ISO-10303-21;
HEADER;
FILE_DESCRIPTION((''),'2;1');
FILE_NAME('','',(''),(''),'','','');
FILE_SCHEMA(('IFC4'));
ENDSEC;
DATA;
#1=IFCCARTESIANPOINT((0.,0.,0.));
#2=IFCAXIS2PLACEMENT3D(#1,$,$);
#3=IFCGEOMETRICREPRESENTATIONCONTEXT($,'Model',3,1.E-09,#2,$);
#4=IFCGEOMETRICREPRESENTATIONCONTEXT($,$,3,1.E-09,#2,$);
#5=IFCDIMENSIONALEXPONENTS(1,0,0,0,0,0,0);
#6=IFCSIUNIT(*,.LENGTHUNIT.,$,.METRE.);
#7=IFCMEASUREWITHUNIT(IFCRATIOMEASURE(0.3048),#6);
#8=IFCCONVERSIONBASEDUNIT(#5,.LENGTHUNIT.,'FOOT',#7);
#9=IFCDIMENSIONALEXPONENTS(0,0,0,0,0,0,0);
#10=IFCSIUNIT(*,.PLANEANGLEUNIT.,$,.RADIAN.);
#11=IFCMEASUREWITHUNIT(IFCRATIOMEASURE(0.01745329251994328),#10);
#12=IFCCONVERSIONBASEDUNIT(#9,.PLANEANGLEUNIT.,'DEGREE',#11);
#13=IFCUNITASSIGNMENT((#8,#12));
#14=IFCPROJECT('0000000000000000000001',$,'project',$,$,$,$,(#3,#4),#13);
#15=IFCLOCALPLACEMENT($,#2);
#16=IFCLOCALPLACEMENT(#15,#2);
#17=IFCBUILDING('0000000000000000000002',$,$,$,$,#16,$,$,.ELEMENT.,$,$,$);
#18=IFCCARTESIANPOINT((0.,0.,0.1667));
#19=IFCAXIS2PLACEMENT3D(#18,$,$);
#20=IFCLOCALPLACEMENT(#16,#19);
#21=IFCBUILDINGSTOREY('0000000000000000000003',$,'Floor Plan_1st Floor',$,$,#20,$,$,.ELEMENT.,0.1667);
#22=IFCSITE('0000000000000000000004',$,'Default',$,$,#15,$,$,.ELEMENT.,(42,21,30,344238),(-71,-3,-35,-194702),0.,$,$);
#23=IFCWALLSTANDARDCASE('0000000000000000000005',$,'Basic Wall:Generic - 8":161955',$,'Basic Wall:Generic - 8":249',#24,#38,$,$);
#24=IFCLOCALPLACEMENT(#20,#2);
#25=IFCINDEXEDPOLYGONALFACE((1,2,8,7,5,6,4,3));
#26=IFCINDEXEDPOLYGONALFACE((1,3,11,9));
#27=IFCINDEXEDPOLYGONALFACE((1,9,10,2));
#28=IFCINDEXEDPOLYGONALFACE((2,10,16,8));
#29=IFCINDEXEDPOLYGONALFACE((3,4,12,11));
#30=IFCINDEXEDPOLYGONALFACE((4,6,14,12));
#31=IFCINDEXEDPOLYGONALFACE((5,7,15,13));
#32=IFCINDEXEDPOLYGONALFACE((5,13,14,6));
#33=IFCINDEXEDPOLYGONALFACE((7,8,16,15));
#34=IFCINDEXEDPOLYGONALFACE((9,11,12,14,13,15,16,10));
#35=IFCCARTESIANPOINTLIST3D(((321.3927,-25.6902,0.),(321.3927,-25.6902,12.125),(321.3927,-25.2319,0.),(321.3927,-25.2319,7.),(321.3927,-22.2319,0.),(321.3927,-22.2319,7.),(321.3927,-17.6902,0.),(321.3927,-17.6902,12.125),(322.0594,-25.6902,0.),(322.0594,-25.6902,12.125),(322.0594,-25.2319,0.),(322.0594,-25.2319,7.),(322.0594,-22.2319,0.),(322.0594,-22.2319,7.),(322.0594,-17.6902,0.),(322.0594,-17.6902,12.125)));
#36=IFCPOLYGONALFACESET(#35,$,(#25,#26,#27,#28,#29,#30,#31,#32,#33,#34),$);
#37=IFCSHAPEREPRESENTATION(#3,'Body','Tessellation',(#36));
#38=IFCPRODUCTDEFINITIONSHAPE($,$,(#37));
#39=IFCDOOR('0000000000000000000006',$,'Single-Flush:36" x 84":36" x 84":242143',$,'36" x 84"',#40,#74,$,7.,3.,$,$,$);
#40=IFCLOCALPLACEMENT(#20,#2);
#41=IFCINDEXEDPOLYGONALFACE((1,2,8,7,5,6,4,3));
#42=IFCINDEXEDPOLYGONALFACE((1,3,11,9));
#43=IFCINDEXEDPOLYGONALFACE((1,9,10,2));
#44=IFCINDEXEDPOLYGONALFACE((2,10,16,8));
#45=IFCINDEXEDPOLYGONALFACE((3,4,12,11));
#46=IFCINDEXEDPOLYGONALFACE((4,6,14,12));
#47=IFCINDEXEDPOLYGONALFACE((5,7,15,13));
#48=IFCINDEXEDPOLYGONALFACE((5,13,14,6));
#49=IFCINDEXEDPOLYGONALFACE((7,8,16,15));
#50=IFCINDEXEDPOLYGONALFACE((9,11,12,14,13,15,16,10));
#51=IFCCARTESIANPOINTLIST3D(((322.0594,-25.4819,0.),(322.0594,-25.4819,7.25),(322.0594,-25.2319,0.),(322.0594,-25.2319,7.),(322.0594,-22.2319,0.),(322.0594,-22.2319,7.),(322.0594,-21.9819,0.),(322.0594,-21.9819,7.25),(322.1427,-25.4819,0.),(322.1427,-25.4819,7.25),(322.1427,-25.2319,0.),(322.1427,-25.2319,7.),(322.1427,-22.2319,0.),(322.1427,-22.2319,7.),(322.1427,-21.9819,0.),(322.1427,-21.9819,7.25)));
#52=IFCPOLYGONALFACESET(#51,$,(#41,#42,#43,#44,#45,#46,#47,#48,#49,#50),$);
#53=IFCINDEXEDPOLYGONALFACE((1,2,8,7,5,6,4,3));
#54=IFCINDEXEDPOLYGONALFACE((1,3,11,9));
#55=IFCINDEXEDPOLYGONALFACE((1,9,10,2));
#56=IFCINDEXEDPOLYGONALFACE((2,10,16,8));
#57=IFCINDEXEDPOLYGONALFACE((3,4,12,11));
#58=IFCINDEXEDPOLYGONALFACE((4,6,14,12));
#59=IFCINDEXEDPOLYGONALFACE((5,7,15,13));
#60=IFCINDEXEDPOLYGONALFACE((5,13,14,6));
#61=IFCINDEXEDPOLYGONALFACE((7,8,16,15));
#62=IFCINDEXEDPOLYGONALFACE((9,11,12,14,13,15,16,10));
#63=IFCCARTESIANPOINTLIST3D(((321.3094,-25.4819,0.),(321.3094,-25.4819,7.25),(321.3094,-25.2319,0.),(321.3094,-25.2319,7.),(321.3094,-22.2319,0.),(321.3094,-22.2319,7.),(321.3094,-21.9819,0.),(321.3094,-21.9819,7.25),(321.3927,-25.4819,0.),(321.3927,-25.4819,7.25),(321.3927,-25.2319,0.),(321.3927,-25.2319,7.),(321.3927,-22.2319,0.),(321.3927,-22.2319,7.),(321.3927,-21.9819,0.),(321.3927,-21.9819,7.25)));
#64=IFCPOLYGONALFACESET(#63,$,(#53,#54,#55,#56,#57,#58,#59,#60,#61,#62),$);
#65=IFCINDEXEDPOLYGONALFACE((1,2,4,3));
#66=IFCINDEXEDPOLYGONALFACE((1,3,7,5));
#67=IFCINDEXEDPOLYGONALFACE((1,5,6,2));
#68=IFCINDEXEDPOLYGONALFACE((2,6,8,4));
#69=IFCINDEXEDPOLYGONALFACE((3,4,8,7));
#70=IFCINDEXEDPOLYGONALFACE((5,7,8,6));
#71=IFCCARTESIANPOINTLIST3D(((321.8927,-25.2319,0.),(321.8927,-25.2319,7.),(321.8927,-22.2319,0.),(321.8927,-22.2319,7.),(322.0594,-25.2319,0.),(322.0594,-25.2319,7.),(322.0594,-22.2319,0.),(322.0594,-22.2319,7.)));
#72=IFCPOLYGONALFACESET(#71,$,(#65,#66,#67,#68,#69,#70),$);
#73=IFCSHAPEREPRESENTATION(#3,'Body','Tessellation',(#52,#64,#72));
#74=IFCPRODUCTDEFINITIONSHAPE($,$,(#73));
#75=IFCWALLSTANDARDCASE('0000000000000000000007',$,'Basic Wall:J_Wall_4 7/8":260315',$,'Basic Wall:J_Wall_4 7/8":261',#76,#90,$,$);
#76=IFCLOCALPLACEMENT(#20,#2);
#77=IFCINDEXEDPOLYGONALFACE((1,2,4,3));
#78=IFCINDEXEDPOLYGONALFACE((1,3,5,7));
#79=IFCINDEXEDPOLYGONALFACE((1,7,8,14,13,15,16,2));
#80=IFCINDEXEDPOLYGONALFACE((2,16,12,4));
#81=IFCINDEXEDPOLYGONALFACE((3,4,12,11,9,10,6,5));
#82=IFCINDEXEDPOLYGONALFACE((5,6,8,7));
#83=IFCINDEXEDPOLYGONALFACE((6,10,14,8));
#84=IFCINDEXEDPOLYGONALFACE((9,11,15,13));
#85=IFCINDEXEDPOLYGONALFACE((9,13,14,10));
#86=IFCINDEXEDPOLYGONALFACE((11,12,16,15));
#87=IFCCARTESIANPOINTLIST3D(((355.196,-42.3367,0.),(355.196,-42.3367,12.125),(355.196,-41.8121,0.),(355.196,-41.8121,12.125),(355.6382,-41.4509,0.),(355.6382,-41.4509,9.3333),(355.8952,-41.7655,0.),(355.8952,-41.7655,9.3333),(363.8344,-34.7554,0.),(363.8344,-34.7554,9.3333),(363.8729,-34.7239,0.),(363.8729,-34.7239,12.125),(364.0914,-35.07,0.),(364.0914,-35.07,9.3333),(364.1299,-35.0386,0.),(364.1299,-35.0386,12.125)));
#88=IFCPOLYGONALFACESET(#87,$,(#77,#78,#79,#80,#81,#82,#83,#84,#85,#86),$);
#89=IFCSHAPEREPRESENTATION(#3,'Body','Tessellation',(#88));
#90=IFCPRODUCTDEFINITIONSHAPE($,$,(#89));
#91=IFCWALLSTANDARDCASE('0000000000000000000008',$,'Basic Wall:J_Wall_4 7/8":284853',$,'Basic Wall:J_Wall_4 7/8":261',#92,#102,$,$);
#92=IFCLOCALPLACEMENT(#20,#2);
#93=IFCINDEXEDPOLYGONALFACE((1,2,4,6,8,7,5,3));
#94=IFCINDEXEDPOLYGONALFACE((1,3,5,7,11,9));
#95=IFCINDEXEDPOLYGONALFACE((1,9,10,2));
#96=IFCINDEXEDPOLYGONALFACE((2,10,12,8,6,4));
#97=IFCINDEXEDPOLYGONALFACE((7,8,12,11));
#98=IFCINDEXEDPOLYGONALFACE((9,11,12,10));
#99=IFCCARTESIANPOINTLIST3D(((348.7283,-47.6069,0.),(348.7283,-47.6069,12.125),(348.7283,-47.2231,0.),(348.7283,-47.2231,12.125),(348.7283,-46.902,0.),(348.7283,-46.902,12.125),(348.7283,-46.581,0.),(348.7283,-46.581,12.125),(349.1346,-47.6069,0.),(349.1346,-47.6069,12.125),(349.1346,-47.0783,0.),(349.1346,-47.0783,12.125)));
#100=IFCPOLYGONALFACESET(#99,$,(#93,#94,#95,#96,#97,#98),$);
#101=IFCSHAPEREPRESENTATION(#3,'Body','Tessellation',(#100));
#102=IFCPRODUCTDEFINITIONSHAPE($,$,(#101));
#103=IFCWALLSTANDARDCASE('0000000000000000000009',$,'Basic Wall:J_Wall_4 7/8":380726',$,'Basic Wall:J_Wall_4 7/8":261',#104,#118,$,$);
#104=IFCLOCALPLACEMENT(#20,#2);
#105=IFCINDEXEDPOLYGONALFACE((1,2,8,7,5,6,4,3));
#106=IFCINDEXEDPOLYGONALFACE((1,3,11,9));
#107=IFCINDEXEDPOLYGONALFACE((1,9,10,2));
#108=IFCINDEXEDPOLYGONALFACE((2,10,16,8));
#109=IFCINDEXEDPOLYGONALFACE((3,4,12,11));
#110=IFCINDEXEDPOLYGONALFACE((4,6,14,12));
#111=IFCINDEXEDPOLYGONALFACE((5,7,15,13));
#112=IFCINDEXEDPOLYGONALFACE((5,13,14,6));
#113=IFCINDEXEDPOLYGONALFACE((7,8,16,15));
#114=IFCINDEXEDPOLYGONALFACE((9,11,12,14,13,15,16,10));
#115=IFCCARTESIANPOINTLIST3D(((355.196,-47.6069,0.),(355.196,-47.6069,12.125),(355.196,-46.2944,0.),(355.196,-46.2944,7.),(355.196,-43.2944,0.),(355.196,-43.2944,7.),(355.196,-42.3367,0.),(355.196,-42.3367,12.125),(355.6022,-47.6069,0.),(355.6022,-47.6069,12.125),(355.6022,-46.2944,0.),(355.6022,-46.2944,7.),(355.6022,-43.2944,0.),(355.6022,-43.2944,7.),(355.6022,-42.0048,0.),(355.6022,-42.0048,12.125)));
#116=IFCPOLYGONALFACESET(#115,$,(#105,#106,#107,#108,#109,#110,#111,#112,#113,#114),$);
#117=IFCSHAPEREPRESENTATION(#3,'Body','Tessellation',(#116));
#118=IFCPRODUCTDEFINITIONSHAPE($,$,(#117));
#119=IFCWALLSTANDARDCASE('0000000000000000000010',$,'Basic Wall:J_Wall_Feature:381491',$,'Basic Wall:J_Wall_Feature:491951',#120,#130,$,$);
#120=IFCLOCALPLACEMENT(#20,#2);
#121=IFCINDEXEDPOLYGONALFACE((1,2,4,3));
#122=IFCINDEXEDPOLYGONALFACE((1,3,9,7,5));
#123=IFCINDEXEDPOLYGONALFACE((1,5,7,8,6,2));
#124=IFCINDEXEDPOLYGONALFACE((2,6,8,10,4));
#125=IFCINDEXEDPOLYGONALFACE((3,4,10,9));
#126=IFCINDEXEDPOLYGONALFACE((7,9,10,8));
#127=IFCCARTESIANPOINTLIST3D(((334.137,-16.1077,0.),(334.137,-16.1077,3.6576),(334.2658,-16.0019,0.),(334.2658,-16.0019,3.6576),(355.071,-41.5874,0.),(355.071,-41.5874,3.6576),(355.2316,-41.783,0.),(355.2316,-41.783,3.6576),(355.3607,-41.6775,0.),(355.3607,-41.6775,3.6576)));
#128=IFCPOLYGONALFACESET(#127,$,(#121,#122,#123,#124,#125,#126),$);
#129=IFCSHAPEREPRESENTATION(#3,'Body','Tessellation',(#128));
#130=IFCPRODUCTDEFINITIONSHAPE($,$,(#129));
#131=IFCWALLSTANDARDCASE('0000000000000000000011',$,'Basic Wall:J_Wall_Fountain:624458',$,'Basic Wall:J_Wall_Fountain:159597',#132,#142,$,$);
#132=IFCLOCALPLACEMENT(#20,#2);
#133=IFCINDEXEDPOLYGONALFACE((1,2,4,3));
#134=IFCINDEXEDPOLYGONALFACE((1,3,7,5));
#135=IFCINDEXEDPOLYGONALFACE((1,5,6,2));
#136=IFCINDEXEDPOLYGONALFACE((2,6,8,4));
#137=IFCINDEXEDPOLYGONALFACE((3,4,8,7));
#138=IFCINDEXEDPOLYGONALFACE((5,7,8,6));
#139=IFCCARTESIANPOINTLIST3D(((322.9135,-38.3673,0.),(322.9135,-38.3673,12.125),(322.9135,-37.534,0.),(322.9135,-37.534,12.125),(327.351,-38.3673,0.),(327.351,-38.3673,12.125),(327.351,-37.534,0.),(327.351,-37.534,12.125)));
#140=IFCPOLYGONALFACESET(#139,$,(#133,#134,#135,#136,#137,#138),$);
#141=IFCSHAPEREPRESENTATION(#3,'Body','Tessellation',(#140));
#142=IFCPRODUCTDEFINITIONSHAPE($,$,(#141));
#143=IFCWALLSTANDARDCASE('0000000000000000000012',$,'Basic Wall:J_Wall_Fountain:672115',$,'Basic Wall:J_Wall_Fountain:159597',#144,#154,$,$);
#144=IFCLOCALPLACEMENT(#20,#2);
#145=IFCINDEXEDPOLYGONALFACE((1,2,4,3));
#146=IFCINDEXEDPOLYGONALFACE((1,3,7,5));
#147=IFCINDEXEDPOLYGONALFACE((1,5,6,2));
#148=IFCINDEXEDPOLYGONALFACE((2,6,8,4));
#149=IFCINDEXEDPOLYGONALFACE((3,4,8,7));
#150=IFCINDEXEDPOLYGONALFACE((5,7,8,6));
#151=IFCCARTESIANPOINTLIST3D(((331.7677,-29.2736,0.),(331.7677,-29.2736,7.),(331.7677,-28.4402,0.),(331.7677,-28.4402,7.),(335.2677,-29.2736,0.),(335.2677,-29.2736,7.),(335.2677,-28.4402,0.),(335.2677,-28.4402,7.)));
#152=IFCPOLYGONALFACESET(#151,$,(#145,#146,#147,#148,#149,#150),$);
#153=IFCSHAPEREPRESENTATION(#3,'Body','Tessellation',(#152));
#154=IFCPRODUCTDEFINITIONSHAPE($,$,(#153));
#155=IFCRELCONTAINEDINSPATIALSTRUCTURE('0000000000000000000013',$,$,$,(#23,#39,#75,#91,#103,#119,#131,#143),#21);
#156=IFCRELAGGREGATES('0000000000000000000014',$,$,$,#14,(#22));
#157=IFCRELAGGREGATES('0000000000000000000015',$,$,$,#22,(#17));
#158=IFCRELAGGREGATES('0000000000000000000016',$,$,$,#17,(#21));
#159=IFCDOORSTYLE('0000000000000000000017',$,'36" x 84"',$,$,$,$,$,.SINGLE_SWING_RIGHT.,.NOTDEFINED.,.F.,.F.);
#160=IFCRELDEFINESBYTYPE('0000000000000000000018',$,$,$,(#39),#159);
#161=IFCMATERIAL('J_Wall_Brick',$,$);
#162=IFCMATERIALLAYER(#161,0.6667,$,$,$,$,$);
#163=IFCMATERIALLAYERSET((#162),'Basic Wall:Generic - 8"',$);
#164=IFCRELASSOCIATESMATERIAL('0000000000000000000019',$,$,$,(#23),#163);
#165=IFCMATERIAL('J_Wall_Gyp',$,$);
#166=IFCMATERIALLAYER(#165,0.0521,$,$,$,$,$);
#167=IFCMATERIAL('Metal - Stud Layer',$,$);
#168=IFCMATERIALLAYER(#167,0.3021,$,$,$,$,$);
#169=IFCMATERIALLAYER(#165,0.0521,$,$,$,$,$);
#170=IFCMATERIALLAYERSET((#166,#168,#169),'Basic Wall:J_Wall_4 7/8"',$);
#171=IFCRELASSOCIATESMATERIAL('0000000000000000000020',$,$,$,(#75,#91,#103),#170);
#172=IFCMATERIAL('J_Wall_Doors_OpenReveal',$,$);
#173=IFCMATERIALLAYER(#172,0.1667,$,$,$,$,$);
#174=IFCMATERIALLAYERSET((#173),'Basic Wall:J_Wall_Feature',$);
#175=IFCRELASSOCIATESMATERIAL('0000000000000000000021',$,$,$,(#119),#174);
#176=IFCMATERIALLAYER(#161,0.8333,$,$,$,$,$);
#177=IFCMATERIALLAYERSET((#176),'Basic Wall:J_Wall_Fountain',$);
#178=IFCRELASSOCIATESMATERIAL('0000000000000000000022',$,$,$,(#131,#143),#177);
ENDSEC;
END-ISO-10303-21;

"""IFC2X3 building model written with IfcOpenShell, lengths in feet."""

from ifc_helpers import new_model, entity, si_unit, converted_unit, frame, frame_2d, origin, origin_2d_with_axis, place, context, project, spatial, polyline, rectangle, outline, extrude, source, transform, mapped, material, layer, layer_set, layer_usage, type_object, type_shapes, element, fill, save


model = new_model("IFC2X3")

# Units and contexts
model_context = context("Model", 3, precision=1e-09, world=origin())
context_of_model = context(None, 3, precision=1e-09, world=origin())
ifc_project = project(units=[converted_unit("LENGTHUNIT", "FOOT", entity("IfcRatioMeasure", 0.3048), si_unit("LENGTHUNIT", "METRE"), dimensions=[1, 0, 0, 0, 0, 0, 0]), converted_unit("PLANEANGLEUNIT", "DEGREE", entity("IfcRatioMeasure", 0.01745329251994328), si_unit("PLANEANGLEUNIT", "RADIAN"), dimensions=[0, 0, 0, 0, 0, 0, 0])], contexts=[model_context, context_of_model])

# Site, building, storey
site_placement = place(None, origin())
site = spatial("IfcSite", under=ifc_project, at=site_placement, Name="Default", CompositionType="ELEMENT", RefLatitude=(42, 21, 30, 344238), RefLongitude=(-71, -3, -35, -194702), RefElevation=0.0)
building_placement = place(site_placement, origin())
building = spatial("IfcBuilding", under=site, at=building_placement, CompositionType="ELEMENT")
storey_placement = place(building_placement, frame((0.0, 0.0, 0.1667)))
storey = spatial("IfcBuildingStorey", under=building, at=storey_placement, Name="Floor Plan_1st Floor", CompositionType="ELEMENT", Elevation=0.1667)

# Shared definitions
ifc_material_1 = material(Name="J_Wall_Brick")
ifc_layer_1 = layer(ifc_material_1, 0.8333)
ifc_layer_set_1 = layer_set([ifc_layer_1], Name="Basic Wall:J_Wall_Fountain")

# Wall, opening, door
ifc_layer_2 = layer(ifc_material_1, 0.6667)
ifc_layer_set_2 = layer_set([ifc_layer_2], Name="Basic Wall:Generic - 8\"")
ifc_layer_usage_1 = layer_usage(ifc_layer_set_2, "AXIS2", "NEGATIVE", 0.3333)
wall_1_placement = place(storey_placement, frame((321.726, -25.6902, 0.0), z_axis=(0.0, 0.0, 1.0), x_axis=(0.0, 1.0, 0.0)))
wall_1 = element("IfcWallStandardCase", 1, at=wall_1_placement, inside=storey, material=ifc_layer_usage_1, Name="Basic Wall:Generic - 8\":161955", ObjectType="Basic Wall:Generic - 8\":249", context=model_context, shape_type="SweptSolid", body=[
    extrude(rectangle(XDim=8.0, YDim=0.6667, at=frame_2d((4.0, 0.0), x_axis=(-1.0, 0.0))), origin(), (0.0, 0.0, 1.0), 12.125),
])
opening_1_placement = place(wall_1_placement, frame((3.4583, 0.3333, 0.0)))
opening_1 = element("IfcOpeningElement", 2, at=opening_1_placement, cuts=wall_1, ObjectType="Opening", context=model_context, shape_type="SweptSolid", body=[
    extrude(rectangle(XDim=3.0, YDim=7.0, at=frame_2d((3.5, 1.5), x_axis=(0.0, 1.0))), frame((0.0, 0.0, 0.0), z_axis=(0.0, -1.0, 0.0), x_axis=(0.0, 0.0, 1.0)), (0.0, 0.0, 1.0), 0.6667),
])
door_style_1 = type_object("IfcDoorStyle", Name="36\" x 84\"", ConstructionType="NOTDEFINED", OperationType="SINGLE_SWING_RIGHT", ParameterTakesPrecedence=False, Sizeable=False)
shared_shape_1 = source(origin(), model_context, "Body", "SweptSolid", [
    extrude(outline(polyline([(-1.75, -3.6875), (1.75, -3.6875), (1.75, 3.5625), (1.5, 3.5625), (1.5, -3.4375), (-1.5, -3.4375), (-1.5, 3.5625), (-1.75, 3.5625), (-1.75, -3.6875)])), frame((1.5, 0.6667, 3.5625), z_axis=(0.0, 1.0, 0.0), x_axis=(1.0, 0.0, 0.0)), (0.0, 0.0, 1.0), 0.0833),
    extrude(outline(polyline([(-3.6875, -1.75), (3.5625, -1.75), (3.5625, -1.5), (-3.4375, -1.5), (-3.4375, 1.5), (3.5625, 1.5), (3.5625, 1.75), (-3.6875, 1.75), (-3.6875, -1.75)])), frame((1.5, -0.0833, 3.5625), z_axis=(0.0, 1.0, 0.0), x_axis=(0.0, 0.0, -1.0)), (0.0, 0.0, 1.0), 0.0833),
    extrude(rectangle(XDim=0.1667, YDim=3.0, at=origin_2d_with_axis()), frame((1.5, 0.5833, 0.0), z_axis=(0.0, 0.0, 1.0), x_axis=(0.0, 1.0, 0.0)), (0.0, 0.0, 1.0), 7.0),
])
type_shapes(door_style_1, [shared_shape_1])
door_1_placement = place(opening_1_placement, frame((0.0, 0.0, 0.0), z_axis=(0.0, 0.0, 1.0), x_axis=(-1.0, 0.0, 0.0)))
door_1 = element("IfcDoor", 3, at=door_1_placement, inside=storey, type_object=door_style_1, Name="Single-Flush:36\" x 84\":36\" x 84\":242143", ObjectType="36\" x 84\"", OverallHeight=7.0, OverallWidth=3.0, context=model_context, shape_type="MappedRepresentation", body=[
    mapped(shared_shape_1, transform((0.0, 0.0, 0.0), scale=1.0)),
])
fill(opening_1, door_1)

# Wall, opening
ifc_material_2 = material(Name="J_Wall_Gyp")
ifc_layer_3 = layer(ifc_material_2, 0.0521)
ifc_material_3 = material(Name="Metal - Stud Layer")
ifc_layer_4 = layer(ifc_material_3, 0.3021)
ifc_layer_5 = layer(ifc_material_2, 0.0521)
ifc_layer_set_3 = layer_set([ifc_layer_3, ifc_layer_4, ifc_layer_5], Name="Basic Wall:J_Wall_4 7/8\"")
ifc_layer_usage_2 = layer_usage(ifc_layer_set_3, "AXIS2", "NEGATIVE", 0.2031)
wall_2_placement = place(storey_placement, frame((355.0675, -42.1794, 0.0), z_axis=(0.0, 0.0, 1.0), x_axis=(0.774444, 0.632643, 0.0)))
wall_2 = element("IfcWallStandardCase", 4, at=wall_2_placement, inside=storey, material=ifc_layer_usage_2, Name="Basic Wall:J_Wall_4 7/8\":260315", ObjectType="Basic Wall:J_Wall_4 7/8\":261", context=model_context, shape_type="SweptSolid", body=[
    extrude(outline(polyline([(0.0, -0.2031), (0.5246, -0.2031), (11.536, -0.2031), (11.536, 0.2031), (0.5446, 0.2031), (0.3779, 0.2031), (0.3319, 0.2031), (0.0, -0.2031)])), origin(), (0.0, 0.0, 1.0), 12.125),
])
opening_2_placement = place(wall_2_placement, frame((0.9029, -0.2031, 0.0)))
element("IfcOpeningElement", 5, at=opening_2_placement, cuts=wall_2, ObjectType="Opening", context=model_context, shape_type="SweptSolid", body=[
    extrude(rectangle(XDim=9.3333, YDim=10.5833, at=frame_2d((4.6667, 5.2917), x_axis=(1.0, 0.0))), frame((0.0, 0.0, 0.0), z_axis=(0.0, 1.0, 0.0), x_axis=(0.0, 0.0, 1.0)), (0.0, 0.0, 1.0), 0.4062),
])

# Wall
ifc_layer_usage_3 = layer_usage(ifc_layer_set_3, "AXIS2", "NEGATIVE", 0.2031)
wall_3_placement = place(storey_placement, frame((348.9314, -46.581, 0.0), z_axis=(0.0, 0.0, 1.0), x_axis=(0.0, -1.0, 0.0)))
element("IfcWallStandardCase", 6, at=wall_3_placement, inside=storey, material=ifc_layer_usage_3, Name="Basic Wall:J_Wall_4 7/8\":284853", ObjectType="Basic Wall:J_Wall_4 7/8\":261", context=model_context, shape_type="SweptSolid", body=[
    extrude(outline(polyline([(1.0259, -0.2031), (1.0259, 0.2031), (0.4973, 0.2031), (0.0, -0.2031), (0.3211, -0.2031), (0.6421, -0.2031), (1.0259, -0.2031)])), origin(), (0.0, 0.0, 1.0), 12.125),
])

# Wall, opening
ifc_layer_usage_4 = layer_usage(ifc_layer_set_3, "AXIS2", "NEGATIVE", 0.2031)
wall_4_placement = place(storey_placement, frame((355.3991, -42.0048, 0.0), z_axis=(0.0, 0.0, 1.0), x_axis=(0.0, -1.0, 0.0)))
wall_4 = element("IfcWallStandardCase", 7, at=wall_4_placement, inside=storey, material=ifc_layer_usage_4, Name="Basic Wall:J_Wall_4 7/8\":380726", ObjectType="Basic Wall:J_Wall_4 7/8\":261", context=model_context, shape_type="SweptSolid", body=[
    extrude(outline(polyline([(0.3319, -0.2031), (5.6021, -0.2031), (5.6021, 0.2031), (0.0, 0.2031), (0.3319, -0.2031)])), origin(), (0.0, 0.0, 1.0), 12.125),
])
opening_3_placement = place(wall_4_placement, frame((1.2896, -0.2031, 0.0)))
element("IfcOpeningElement", 8, at=opening_3_placement, cuts=wall_4, ObjectType="Opening", context=model_context, shape_type="SweptSolid", body=[
    extrude(rectangle(XDim=3.0, YDim=7.0, at=frame_2d((3.5, 1.5), x_axis=(0.0, 1.0))), frame((0.0, 0.0, 0.0), z_axis=(0.0, 1.0, 0.0), x_axis=(0.0, 0.0, 1.0)), (0.0, 0.0, 1.0), 0.4062),
])

# Wall
ifc_material_4 = material(Name="J_Wall_Doors_OpenReveal")
ifc_layer_6 = layer(ifc_material_4, 0.1667)
ifc_layer_set_4 = layer_set([ifc_layer_6], Name="Basic Wall:J_Wall_Feature")
ifc_layer_usage_5 = layer_usage(ifc_layer_set_4, "AXIS2", "NEGATIVE", 0.0833)
wall_5_placement = place(storey_placement, frame((355.2963, -41.7304, 0.0), z_axis=(0.0, 0.0, 1.0), x_axis=(-0.634816, 0.772664, 0.0)))
element("IfcWallStandardCase", 9, at=wall_5_placement, inside=storey, material=ifc_layer_usage_5, Name="Basic Wall:J_Wall_Feature:381491", ObjectType="Basic Wall:J_Wall_Feature:491951", context=model_context, shape_type="SweptSolid", body=[
    extrude(outline(polyline([(33.23, -0.0833), (33.23, 0.0833), (0.2536, 0.0833), (0.0005, 0.0833), (0.0, -0.0833), (33.23, -0.0833)])), origin(), (0.0, 0.0, 1.0), 3.6576),
])

# Walls
ifc_layer_usage_6 = layer_usage(ifc_layer_set_1, "AXIS2", "NEGATIVE", 0.4167)
wall_6_placement = place(storey_placement, frame((327.351, -37.9507, 0.0), z_axis=(0.0, 0.0, 1.0), x_axis=(-1.0, 0.0, 0.0)))
element("IfcWallStandardCase", 10, at=wall_6_placement, inside=storey, material=ifc_layer_usage_6, Name="Basic Wall:J_Wall_Fountain:624458", ObjectType="Basic Wall:J_Wall_Fountain:159597", context=model_context, shape_type="SweptSolid", body=[
    extrude(rectangle(XDim=4.4375, YDim=0.8333, at=frame_2d((2.2188, 0.0), x_axis=(-1.0, 0.0))), origin(), (0.0, 0.0, 1.0), 12.125),
])
ifc_layer_usage_7 = layer_usage(ifc_layer_set_1, "AXIS2", "NEGATIVE", 0.4167)
wall_7_placement = place(storey_placement, frame((331.7677, -28.8569, 0.0)))
element("IfcWallStandardCase", 11, at=wall_7_placement, inside=storey, material=ifc_layer_usage_7, Name="Basic Wall:J_Wall_Fountain:672115", ObjectType="Basic Wall:J_Wall_Fountain:159597", context=model_context, shape_type="SweptSolid", body=[
    extrude(rectangle(XDim=3.5, YDim=0.8333, at=frame_2d((1.75, 0.0), x_axis=(-1.0, 0.0))), origin(), (0.0, 0.0, 1.0), 7.0),
])

save(model, "model.ifc")
